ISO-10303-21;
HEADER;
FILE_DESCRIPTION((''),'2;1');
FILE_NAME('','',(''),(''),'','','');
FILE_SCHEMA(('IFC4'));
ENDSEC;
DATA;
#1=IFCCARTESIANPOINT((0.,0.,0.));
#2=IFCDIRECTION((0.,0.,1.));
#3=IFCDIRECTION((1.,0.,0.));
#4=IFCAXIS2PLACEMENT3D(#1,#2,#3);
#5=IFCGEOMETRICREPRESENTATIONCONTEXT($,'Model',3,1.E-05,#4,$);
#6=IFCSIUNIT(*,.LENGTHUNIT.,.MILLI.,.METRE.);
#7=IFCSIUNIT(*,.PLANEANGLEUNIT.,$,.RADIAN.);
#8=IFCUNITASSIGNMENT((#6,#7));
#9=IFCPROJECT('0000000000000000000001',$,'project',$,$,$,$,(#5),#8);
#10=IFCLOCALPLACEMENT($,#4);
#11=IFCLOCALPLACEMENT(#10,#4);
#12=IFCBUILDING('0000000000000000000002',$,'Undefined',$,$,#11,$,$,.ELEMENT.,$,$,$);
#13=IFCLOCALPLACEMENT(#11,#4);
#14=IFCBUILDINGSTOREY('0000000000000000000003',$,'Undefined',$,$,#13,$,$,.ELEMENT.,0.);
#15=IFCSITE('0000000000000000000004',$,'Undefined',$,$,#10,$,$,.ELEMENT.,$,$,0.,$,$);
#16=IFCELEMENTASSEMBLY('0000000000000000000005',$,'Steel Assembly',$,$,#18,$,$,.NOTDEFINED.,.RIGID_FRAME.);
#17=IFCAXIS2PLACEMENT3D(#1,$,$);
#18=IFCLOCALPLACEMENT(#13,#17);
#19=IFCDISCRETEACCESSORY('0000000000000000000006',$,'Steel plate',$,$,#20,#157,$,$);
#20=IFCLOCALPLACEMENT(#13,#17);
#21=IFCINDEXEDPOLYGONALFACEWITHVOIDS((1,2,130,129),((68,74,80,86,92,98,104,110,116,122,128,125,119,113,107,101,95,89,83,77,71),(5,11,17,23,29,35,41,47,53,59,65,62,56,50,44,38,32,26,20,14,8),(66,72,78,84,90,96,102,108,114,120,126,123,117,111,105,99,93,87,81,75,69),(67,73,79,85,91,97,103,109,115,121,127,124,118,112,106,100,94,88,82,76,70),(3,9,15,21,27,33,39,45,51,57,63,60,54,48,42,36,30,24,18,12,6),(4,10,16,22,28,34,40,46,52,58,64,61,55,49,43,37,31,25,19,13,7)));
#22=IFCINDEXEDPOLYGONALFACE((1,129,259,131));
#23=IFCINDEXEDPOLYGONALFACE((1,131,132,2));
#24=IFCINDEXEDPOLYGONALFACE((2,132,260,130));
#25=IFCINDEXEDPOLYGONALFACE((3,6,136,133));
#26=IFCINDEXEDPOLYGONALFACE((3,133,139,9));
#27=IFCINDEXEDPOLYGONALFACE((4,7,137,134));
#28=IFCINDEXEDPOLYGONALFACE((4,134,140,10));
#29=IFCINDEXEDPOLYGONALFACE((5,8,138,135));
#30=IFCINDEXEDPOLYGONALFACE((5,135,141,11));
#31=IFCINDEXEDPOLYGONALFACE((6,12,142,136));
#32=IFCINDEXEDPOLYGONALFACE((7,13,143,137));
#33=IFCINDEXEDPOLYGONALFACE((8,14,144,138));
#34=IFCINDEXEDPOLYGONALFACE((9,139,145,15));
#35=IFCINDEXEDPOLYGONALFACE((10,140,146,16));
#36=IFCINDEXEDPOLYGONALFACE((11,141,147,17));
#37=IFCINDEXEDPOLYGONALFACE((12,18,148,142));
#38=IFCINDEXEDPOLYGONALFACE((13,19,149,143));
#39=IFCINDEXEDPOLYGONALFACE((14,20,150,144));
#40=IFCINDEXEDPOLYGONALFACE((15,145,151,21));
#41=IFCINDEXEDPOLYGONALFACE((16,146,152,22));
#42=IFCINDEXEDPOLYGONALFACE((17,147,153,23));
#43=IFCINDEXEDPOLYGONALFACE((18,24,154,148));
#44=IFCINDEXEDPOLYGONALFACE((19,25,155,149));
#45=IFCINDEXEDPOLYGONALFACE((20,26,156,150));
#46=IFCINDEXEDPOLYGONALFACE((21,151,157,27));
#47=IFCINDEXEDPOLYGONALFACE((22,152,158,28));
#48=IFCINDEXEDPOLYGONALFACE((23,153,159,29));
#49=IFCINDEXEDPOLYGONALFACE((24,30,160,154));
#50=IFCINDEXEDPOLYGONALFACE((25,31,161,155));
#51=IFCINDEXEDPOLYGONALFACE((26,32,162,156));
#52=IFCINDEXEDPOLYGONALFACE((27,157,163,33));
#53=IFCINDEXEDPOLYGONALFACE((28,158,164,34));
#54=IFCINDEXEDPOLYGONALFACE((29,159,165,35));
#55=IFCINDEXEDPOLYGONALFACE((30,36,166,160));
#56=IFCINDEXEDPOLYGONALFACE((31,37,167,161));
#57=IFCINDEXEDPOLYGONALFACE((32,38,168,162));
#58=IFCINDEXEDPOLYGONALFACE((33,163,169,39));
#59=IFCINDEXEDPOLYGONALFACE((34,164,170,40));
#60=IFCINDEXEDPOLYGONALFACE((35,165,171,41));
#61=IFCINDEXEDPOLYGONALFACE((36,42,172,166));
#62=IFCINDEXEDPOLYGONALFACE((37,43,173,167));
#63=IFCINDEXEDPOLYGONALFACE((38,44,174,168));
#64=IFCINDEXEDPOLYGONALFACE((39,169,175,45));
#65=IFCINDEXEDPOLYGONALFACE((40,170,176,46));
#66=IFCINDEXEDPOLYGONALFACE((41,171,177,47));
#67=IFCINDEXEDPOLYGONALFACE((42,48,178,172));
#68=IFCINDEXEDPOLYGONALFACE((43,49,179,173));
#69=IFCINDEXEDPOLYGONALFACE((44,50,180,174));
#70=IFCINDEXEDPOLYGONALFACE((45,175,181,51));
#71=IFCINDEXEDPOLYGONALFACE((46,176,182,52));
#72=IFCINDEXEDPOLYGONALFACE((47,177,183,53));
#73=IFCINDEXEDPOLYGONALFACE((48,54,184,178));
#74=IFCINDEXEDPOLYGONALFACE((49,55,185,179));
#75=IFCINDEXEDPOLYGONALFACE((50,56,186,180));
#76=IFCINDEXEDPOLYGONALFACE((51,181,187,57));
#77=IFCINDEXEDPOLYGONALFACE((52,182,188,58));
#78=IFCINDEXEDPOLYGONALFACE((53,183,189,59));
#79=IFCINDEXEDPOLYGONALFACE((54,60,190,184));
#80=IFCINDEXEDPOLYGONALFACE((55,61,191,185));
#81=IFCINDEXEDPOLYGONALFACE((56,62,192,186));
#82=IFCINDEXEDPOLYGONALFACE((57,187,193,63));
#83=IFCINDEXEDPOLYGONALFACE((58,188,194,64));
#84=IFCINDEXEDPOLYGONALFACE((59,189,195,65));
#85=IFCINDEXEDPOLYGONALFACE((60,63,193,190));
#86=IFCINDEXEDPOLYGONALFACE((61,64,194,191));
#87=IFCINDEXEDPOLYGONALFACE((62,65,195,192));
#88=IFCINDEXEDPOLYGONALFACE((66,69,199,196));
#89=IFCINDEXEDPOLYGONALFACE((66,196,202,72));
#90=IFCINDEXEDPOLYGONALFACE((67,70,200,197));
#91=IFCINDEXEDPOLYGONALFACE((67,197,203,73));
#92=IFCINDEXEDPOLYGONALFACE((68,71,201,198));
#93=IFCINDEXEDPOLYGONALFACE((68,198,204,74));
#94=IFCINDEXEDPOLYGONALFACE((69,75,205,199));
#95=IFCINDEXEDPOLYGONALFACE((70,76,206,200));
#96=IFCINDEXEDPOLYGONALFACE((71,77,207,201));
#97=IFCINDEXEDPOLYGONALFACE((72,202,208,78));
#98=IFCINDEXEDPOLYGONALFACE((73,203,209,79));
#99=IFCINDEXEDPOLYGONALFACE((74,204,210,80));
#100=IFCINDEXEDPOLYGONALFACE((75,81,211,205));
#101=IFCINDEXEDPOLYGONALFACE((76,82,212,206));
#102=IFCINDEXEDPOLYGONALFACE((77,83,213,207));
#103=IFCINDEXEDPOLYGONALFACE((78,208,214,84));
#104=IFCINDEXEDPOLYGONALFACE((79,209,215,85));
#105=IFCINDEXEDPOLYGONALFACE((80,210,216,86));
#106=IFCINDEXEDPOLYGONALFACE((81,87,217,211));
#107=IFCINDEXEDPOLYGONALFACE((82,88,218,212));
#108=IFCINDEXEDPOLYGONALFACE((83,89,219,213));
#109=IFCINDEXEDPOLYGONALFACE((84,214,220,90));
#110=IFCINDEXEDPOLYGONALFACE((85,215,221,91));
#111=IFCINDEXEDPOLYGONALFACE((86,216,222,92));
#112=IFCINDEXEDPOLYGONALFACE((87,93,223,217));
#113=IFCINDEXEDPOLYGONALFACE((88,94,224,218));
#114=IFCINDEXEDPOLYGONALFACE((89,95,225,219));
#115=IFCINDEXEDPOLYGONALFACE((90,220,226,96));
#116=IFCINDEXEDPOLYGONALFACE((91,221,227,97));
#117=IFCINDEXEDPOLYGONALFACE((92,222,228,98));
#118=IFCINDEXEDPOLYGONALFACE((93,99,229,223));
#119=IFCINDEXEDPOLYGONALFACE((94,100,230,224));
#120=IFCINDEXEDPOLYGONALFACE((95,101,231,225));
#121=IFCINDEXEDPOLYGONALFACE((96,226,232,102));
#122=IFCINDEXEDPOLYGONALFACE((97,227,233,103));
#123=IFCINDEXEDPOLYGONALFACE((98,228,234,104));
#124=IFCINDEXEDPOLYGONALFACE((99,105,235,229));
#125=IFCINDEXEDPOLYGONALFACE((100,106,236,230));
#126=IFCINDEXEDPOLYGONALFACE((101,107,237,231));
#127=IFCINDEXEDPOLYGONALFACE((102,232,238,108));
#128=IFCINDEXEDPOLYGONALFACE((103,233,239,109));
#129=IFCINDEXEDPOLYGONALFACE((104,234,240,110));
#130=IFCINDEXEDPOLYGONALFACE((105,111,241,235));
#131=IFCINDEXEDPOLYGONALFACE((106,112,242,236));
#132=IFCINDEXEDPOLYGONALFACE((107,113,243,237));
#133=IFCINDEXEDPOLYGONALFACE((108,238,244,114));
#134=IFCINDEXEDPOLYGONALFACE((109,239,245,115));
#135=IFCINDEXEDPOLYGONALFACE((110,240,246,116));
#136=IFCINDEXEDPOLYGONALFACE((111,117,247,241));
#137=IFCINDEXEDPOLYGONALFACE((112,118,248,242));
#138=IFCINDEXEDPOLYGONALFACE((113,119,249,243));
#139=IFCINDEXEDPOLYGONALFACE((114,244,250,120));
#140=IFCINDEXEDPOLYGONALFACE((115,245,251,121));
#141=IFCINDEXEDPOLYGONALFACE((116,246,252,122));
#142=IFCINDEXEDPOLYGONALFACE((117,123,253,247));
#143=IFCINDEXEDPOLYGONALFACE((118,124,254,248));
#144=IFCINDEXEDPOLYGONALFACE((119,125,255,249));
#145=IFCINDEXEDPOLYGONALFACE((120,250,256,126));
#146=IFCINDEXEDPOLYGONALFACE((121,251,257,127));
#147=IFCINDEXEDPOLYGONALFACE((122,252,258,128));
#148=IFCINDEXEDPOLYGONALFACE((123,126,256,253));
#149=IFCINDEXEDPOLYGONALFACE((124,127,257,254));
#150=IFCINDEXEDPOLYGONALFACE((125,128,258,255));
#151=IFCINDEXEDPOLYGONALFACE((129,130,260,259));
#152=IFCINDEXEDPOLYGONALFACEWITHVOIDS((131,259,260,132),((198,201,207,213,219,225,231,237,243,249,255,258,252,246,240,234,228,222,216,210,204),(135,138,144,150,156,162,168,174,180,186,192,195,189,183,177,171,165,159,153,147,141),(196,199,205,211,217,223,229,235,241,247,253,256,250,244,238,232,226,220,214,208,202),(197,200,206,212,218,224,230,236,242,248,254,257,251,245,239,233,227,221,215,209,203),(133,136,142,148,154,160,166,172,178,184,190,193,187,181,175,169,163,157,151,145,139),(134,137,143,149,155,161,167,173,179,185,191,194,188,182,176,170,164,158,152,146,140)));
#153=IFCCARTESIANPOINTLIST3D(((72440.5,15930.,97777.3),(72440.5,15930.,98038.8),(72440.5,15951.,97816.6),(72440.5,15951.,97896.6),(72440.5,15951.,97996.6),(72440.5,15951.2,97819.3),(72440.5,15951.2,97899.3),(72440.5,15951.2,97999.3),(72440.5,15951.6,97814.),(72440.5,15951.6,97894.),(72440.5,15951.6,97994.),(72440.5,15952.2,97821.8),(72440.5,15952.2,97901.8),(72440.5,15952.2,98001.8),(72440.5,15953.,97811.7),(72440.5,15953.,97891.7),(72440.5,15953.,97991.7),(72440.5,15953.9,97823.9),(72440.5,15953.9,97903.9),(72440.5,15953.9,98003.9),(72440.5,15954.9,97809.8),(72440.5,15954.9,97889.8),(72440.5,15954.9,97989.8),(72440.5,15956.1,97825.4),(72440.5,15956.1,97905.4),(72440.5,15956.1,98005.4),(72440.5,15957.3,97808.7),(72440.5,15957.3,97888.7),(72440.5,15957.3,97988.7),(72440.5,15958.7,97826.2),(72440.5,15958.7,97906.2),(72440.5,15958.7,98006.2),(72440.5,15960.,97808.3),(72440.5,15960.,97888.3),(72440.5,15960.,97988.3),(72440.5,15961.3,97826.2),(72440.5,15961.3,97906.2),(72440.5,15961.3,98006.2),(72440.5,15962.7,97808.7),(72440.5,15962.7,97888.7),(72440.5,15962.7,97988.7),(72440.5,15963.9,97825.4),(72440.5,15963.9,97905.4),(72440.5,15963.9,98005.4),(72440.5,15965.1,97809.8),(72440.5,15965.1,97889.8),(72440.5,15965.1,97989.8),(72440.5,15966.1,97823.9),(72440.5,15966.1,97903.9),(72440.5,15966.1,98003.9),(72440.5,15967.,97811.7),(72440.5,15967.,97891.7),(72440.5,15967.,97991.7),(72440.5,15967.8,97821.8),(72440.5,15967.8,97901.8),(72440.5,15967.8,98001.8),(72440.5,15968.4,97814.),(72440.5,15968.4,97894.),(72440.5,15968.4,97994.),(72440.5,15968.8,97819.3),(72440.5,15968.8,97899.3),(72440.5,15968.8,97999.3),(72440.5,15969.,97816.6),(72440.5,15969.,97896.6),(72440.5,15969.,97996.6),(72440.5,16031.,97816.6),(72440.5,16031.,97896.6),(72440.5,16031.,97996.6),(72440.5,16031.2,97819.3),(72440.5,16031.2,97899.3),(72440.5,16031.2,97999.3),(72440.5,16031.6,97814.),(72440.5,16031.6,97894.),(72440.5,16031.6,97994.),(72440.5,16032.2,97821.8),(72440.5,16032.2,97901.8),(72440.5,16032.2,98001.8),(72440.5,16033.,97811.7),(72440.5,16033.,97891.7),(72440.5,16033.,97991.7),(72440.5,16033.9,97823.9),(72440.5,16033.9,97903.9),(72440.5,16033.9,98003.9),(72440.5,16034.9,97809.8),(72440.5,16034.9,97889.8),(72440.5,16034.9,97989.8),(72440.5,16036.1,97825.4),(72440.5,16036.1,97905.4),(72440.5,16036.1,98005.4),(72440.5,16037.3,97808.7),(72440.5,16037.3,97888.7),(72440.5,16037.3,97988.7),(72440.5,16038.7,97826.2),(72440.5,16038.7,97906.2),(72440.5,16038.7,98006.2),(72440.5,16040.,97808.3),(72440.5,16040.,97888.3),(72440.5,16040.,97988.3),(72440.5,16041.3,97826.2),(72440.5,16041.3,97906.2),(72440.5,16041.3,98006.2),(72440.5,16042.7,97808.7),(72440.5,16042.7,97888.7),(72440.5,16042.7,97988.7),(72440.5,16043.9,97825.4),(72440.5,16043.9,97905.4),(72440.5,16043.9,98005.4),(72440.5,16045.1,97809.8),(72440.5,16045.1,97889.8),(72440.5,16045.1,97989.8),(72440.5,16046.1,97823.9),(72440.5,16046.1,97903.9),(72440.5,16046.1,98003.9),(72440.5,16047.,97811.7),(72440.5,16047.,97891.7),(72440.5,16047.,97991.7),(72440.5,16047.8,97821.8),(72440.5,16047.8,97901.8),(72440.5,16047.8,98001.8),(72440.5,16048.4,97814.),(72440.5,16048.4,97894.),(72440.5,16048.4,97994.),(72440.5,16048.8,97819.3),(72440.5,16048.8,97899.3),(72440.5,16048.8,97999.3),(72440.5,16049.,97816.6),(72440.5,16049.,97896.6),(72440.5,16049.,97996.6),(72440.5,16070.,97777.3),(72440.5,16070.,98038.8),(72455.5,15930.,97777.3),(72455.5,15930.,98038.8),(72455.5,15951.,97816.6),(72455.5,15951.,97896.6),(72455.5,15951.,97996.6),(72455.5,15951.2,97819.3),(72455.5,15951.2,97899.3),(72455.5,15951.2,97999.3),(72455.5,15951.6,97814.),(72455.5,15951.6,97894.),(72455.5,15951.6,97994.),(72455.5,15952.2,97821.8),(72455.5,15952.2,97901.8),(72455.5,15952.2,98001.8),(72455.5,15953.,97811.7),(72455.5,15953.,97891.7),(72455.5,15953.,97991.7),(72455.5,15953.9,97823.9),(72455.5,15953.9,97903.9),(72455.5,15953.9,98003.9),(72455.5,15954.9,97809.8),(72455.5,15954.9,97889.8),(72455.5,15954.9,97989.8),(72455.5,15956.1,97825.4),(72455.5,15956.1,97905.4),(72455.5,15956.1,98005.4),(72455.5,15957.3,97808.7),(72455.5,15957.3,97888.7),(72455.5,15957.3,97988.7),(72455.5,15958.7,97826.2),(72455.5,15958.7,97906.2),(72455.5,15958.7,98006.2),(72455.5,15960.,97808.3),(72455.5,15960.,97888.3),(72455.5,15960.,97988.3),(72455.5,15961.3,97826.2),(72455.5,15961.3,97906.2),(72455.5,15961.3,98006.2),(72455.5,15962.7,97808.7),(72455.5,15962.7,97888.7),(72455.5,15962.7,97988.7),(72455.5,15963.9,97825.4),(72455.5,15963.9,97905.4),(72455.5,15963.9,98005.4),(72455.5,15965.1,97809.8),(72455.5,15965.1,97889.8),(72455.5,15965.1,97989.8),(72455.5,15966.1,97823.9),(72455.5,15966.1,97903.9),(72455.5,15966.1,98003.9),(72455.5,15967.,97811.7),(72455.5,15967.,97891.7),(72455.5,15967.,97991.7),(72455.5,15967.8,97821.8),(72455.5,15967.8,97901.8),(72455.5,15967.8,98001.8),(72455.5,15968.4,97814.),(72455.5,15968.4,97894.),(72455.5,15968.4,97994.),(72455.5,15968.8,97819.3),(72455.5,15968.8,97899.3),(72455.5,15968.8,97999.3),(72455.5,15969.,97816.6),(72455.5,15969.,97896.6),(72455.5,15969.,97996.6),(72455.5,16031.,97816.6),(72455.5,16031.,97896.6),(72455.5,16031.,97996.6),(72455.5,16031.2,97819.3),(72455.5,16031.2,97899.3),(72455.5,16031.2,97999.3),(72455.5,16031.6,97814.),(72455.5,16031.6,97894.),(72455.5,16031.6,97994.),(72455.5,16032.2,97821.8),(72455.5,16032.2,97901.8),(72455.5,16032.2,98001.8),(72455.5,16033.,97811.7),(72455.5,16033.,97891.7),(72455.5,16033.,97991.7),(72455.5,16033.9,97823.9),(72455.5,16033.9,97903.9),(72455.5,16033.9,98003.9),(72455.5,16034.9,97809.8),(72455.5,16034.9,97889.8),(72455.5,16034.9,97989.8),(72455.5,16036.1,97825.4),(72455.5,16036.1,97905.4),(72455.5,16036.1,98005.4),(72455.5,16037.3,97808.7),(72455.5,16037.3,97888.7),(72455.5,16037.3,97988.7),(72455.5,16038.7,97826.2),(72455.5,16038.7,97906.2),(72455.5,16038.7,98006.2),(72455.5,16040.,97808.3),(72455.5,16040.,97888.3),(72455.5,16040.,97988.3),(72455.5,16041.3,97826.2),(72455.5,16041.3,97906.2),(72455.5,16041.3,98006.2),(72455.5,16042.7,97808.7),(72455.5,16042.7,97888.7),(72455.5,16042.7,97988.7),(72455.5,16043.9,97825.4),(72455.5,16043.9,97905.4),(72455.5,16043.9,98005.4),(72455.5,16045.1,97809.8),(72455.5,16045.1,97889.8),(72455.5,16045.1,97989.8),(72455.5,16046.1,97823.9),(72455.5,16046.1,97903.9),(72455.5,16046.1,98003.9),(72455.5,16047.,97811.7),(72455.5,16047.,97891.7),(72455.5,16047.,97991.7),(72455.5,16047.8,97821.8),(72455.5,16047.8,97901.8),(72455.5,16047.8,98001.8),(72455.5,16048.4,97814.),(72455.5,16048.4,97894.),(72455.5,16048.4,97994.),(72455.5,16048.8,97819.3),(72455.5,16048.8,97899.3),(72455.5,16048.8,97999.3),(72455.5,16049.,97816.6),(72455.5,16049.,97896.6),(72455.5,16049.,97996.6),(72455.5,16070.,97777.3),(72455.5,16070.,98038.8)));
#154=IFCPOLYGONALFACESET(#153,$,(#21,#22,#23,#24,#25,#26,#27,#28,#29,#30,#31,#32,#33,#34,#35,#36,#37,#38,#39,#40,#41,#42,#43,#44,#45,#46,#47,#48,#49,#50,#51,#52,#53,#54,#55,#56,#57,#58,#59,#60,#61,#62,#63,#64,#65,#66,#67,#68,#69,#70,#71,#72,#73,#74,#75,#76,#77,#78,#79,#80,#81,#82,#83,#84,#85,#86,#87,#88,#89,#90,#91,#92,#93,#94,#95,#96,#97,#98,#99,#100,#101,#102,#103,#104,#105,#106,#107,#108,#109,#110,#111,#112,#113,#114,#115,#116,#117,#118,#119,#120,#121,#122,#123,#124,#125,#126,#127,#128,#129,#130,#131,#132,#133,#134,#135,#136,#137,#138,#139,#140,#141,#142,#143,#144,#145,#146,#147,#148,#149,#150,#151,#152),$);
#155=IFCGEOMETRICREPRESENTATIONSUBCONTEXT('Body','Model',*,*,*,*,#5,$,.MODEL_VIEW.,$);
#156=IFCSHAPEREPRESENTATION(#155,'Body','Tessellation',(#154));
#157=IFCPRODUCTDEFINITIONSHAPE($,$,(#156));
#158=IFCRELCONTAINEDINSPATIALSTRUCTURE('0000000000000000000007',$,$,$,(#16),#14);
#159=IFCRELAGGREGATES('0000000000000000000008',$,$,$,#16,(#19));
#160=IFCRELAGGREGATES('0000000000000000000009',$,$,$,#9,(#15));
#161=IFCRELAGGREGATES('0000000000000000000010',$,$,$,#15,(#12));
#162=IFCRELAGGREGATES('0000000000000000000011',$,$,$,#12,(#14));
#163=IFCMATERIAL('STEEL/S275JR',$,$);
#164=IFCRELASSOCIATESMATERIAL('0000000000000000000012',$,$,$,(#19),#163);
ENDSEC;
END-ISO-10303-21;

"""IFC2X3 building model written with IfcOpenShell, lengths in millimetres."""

from ifc_helpers import new_model, si_unit, frame, origin_with_axes, origin_2d_with_axis, place, context, subcontext, project, spatial, polyline, circle, outline, extrude, source, transform, mapped, material, element, aggregate, save


model = new_model("IFC2X3")

# Units and contexts
model_context = context("Model", 3, precision=1e-05, world=origin_with_axes())
body_context = subcontext(model_context, "Body", "Model", "MODEL_VIEW")
ifc_project = project(units=[si_unit("LENGTHUNIT", "METRE", prefix="MILLI"), si_unit("PLANEANGLEUNIT", "RADIAN")], contexts=[model_context])

# Site, building, storey
site_placement = place(None, origin_with_axes())
site = spatial("IfcSite", under=ifc_project, at=site_placement, Name="Undefined", CompositionType="ELEMENT", RefElevation=0.0)
building_placement = place(site_placement, origin_with_axes())
building = spatial("IfcBuilding", under=site, at=building_placement, Name="Undefined", CompositionType="ELEMENT")
storey_placement = place(building_placement, origin_with_axes())
storey = spatial("IfcBuildingStorey", under=building, at=storey_placement, Name="Undefined", CompositionType="ELEMENT", Elevation=0.0)

# Shared definitions
ifc_material_1 = material(Name="STEEL/S275JR")

# Element assembly
assembly_1_placement = place(storey_placement, origin_with_axes())
assembly_1 = element("IfcElementAssembly", 1, at=assembly_1_placement, inside=storey, Name="Steel Assembly", AssemblyPlace="NOTDEFINED", PredefinedType="RIGID_FRAME")
shared_shape_1 = source(origin_with_axes(), body_context, "Body", "SweptSolid", [
    extrude(circle(Radius=9.0, at=origin_2d_with_axis()), frame((0.0, 0.9, 0.0), z_axis=(0.0, 1.0, 0.0), x_axis=(1.0, 0.0, 0.0)), (0.0, 0.0, 1.0), 16.1),
])

# Discrete accessory, opening
discrete_accessory_1_placement = place(assembly_1_placement, frame((72448.0, 15930.0, 98038.8), z_axis=(-1.0, 0.0, 0.0), x_axis=(0.0, 1.0, 0.0)))
discrete_accessory_1 = element("IfcDiscreteAccessory", 2, at=discrete_accessory_1_placement, material=ifc_material_1, Name="Steel plate", context=body_context, shape_type="SweptSolid", body=[
    extrude(outline(polyline([(0.0, 0.0), (140.0, 0.0), (140.0, 261.5), (0.0, 261.5), (0.0, 0.0)])), frame((0.0, 0.0, -7.5), z_axis=(0.0, 0.0, 1.0), x_axis=(1.0, 0.0, 0.0)), (0.0, 0.0, 1.0), 15.0),
])
opening_1_placement = place(assembly_1_placement, frame((72439.5, 16000.0, 97997.3), z_axis=(0.0, -1.0, 0.0), x_axis=(0.0, 0.0, -1.0)))
element("IfcOpeningElement", 3, at=opening_1_placement, cuts=discrete_accessory_1, ObjectType="Opening", context=body_context, shape_type="MappedRepresentation", body=[
    mapped(shared_shape_1, transform((0.0, 0.0, -40.0))),
    mapped(shared_shape_1, transform((100.0, 0.0, -40.0))),
    mapped(shared_shape_1, transform((180.0, 0.0, -40.0))),
    mapped(shared_shape_1, transform((0.0, 0.0, 40.0))),
    mapped(shared_shape_1, transform((100.0, 0.0, 40.0))),
    mapped(shared_shape_1, transform((180.0, 0.0, 40.0))),
])
aggregate(assembly_1, [discrete_accessory_1])

save(model, "model.ifc")
